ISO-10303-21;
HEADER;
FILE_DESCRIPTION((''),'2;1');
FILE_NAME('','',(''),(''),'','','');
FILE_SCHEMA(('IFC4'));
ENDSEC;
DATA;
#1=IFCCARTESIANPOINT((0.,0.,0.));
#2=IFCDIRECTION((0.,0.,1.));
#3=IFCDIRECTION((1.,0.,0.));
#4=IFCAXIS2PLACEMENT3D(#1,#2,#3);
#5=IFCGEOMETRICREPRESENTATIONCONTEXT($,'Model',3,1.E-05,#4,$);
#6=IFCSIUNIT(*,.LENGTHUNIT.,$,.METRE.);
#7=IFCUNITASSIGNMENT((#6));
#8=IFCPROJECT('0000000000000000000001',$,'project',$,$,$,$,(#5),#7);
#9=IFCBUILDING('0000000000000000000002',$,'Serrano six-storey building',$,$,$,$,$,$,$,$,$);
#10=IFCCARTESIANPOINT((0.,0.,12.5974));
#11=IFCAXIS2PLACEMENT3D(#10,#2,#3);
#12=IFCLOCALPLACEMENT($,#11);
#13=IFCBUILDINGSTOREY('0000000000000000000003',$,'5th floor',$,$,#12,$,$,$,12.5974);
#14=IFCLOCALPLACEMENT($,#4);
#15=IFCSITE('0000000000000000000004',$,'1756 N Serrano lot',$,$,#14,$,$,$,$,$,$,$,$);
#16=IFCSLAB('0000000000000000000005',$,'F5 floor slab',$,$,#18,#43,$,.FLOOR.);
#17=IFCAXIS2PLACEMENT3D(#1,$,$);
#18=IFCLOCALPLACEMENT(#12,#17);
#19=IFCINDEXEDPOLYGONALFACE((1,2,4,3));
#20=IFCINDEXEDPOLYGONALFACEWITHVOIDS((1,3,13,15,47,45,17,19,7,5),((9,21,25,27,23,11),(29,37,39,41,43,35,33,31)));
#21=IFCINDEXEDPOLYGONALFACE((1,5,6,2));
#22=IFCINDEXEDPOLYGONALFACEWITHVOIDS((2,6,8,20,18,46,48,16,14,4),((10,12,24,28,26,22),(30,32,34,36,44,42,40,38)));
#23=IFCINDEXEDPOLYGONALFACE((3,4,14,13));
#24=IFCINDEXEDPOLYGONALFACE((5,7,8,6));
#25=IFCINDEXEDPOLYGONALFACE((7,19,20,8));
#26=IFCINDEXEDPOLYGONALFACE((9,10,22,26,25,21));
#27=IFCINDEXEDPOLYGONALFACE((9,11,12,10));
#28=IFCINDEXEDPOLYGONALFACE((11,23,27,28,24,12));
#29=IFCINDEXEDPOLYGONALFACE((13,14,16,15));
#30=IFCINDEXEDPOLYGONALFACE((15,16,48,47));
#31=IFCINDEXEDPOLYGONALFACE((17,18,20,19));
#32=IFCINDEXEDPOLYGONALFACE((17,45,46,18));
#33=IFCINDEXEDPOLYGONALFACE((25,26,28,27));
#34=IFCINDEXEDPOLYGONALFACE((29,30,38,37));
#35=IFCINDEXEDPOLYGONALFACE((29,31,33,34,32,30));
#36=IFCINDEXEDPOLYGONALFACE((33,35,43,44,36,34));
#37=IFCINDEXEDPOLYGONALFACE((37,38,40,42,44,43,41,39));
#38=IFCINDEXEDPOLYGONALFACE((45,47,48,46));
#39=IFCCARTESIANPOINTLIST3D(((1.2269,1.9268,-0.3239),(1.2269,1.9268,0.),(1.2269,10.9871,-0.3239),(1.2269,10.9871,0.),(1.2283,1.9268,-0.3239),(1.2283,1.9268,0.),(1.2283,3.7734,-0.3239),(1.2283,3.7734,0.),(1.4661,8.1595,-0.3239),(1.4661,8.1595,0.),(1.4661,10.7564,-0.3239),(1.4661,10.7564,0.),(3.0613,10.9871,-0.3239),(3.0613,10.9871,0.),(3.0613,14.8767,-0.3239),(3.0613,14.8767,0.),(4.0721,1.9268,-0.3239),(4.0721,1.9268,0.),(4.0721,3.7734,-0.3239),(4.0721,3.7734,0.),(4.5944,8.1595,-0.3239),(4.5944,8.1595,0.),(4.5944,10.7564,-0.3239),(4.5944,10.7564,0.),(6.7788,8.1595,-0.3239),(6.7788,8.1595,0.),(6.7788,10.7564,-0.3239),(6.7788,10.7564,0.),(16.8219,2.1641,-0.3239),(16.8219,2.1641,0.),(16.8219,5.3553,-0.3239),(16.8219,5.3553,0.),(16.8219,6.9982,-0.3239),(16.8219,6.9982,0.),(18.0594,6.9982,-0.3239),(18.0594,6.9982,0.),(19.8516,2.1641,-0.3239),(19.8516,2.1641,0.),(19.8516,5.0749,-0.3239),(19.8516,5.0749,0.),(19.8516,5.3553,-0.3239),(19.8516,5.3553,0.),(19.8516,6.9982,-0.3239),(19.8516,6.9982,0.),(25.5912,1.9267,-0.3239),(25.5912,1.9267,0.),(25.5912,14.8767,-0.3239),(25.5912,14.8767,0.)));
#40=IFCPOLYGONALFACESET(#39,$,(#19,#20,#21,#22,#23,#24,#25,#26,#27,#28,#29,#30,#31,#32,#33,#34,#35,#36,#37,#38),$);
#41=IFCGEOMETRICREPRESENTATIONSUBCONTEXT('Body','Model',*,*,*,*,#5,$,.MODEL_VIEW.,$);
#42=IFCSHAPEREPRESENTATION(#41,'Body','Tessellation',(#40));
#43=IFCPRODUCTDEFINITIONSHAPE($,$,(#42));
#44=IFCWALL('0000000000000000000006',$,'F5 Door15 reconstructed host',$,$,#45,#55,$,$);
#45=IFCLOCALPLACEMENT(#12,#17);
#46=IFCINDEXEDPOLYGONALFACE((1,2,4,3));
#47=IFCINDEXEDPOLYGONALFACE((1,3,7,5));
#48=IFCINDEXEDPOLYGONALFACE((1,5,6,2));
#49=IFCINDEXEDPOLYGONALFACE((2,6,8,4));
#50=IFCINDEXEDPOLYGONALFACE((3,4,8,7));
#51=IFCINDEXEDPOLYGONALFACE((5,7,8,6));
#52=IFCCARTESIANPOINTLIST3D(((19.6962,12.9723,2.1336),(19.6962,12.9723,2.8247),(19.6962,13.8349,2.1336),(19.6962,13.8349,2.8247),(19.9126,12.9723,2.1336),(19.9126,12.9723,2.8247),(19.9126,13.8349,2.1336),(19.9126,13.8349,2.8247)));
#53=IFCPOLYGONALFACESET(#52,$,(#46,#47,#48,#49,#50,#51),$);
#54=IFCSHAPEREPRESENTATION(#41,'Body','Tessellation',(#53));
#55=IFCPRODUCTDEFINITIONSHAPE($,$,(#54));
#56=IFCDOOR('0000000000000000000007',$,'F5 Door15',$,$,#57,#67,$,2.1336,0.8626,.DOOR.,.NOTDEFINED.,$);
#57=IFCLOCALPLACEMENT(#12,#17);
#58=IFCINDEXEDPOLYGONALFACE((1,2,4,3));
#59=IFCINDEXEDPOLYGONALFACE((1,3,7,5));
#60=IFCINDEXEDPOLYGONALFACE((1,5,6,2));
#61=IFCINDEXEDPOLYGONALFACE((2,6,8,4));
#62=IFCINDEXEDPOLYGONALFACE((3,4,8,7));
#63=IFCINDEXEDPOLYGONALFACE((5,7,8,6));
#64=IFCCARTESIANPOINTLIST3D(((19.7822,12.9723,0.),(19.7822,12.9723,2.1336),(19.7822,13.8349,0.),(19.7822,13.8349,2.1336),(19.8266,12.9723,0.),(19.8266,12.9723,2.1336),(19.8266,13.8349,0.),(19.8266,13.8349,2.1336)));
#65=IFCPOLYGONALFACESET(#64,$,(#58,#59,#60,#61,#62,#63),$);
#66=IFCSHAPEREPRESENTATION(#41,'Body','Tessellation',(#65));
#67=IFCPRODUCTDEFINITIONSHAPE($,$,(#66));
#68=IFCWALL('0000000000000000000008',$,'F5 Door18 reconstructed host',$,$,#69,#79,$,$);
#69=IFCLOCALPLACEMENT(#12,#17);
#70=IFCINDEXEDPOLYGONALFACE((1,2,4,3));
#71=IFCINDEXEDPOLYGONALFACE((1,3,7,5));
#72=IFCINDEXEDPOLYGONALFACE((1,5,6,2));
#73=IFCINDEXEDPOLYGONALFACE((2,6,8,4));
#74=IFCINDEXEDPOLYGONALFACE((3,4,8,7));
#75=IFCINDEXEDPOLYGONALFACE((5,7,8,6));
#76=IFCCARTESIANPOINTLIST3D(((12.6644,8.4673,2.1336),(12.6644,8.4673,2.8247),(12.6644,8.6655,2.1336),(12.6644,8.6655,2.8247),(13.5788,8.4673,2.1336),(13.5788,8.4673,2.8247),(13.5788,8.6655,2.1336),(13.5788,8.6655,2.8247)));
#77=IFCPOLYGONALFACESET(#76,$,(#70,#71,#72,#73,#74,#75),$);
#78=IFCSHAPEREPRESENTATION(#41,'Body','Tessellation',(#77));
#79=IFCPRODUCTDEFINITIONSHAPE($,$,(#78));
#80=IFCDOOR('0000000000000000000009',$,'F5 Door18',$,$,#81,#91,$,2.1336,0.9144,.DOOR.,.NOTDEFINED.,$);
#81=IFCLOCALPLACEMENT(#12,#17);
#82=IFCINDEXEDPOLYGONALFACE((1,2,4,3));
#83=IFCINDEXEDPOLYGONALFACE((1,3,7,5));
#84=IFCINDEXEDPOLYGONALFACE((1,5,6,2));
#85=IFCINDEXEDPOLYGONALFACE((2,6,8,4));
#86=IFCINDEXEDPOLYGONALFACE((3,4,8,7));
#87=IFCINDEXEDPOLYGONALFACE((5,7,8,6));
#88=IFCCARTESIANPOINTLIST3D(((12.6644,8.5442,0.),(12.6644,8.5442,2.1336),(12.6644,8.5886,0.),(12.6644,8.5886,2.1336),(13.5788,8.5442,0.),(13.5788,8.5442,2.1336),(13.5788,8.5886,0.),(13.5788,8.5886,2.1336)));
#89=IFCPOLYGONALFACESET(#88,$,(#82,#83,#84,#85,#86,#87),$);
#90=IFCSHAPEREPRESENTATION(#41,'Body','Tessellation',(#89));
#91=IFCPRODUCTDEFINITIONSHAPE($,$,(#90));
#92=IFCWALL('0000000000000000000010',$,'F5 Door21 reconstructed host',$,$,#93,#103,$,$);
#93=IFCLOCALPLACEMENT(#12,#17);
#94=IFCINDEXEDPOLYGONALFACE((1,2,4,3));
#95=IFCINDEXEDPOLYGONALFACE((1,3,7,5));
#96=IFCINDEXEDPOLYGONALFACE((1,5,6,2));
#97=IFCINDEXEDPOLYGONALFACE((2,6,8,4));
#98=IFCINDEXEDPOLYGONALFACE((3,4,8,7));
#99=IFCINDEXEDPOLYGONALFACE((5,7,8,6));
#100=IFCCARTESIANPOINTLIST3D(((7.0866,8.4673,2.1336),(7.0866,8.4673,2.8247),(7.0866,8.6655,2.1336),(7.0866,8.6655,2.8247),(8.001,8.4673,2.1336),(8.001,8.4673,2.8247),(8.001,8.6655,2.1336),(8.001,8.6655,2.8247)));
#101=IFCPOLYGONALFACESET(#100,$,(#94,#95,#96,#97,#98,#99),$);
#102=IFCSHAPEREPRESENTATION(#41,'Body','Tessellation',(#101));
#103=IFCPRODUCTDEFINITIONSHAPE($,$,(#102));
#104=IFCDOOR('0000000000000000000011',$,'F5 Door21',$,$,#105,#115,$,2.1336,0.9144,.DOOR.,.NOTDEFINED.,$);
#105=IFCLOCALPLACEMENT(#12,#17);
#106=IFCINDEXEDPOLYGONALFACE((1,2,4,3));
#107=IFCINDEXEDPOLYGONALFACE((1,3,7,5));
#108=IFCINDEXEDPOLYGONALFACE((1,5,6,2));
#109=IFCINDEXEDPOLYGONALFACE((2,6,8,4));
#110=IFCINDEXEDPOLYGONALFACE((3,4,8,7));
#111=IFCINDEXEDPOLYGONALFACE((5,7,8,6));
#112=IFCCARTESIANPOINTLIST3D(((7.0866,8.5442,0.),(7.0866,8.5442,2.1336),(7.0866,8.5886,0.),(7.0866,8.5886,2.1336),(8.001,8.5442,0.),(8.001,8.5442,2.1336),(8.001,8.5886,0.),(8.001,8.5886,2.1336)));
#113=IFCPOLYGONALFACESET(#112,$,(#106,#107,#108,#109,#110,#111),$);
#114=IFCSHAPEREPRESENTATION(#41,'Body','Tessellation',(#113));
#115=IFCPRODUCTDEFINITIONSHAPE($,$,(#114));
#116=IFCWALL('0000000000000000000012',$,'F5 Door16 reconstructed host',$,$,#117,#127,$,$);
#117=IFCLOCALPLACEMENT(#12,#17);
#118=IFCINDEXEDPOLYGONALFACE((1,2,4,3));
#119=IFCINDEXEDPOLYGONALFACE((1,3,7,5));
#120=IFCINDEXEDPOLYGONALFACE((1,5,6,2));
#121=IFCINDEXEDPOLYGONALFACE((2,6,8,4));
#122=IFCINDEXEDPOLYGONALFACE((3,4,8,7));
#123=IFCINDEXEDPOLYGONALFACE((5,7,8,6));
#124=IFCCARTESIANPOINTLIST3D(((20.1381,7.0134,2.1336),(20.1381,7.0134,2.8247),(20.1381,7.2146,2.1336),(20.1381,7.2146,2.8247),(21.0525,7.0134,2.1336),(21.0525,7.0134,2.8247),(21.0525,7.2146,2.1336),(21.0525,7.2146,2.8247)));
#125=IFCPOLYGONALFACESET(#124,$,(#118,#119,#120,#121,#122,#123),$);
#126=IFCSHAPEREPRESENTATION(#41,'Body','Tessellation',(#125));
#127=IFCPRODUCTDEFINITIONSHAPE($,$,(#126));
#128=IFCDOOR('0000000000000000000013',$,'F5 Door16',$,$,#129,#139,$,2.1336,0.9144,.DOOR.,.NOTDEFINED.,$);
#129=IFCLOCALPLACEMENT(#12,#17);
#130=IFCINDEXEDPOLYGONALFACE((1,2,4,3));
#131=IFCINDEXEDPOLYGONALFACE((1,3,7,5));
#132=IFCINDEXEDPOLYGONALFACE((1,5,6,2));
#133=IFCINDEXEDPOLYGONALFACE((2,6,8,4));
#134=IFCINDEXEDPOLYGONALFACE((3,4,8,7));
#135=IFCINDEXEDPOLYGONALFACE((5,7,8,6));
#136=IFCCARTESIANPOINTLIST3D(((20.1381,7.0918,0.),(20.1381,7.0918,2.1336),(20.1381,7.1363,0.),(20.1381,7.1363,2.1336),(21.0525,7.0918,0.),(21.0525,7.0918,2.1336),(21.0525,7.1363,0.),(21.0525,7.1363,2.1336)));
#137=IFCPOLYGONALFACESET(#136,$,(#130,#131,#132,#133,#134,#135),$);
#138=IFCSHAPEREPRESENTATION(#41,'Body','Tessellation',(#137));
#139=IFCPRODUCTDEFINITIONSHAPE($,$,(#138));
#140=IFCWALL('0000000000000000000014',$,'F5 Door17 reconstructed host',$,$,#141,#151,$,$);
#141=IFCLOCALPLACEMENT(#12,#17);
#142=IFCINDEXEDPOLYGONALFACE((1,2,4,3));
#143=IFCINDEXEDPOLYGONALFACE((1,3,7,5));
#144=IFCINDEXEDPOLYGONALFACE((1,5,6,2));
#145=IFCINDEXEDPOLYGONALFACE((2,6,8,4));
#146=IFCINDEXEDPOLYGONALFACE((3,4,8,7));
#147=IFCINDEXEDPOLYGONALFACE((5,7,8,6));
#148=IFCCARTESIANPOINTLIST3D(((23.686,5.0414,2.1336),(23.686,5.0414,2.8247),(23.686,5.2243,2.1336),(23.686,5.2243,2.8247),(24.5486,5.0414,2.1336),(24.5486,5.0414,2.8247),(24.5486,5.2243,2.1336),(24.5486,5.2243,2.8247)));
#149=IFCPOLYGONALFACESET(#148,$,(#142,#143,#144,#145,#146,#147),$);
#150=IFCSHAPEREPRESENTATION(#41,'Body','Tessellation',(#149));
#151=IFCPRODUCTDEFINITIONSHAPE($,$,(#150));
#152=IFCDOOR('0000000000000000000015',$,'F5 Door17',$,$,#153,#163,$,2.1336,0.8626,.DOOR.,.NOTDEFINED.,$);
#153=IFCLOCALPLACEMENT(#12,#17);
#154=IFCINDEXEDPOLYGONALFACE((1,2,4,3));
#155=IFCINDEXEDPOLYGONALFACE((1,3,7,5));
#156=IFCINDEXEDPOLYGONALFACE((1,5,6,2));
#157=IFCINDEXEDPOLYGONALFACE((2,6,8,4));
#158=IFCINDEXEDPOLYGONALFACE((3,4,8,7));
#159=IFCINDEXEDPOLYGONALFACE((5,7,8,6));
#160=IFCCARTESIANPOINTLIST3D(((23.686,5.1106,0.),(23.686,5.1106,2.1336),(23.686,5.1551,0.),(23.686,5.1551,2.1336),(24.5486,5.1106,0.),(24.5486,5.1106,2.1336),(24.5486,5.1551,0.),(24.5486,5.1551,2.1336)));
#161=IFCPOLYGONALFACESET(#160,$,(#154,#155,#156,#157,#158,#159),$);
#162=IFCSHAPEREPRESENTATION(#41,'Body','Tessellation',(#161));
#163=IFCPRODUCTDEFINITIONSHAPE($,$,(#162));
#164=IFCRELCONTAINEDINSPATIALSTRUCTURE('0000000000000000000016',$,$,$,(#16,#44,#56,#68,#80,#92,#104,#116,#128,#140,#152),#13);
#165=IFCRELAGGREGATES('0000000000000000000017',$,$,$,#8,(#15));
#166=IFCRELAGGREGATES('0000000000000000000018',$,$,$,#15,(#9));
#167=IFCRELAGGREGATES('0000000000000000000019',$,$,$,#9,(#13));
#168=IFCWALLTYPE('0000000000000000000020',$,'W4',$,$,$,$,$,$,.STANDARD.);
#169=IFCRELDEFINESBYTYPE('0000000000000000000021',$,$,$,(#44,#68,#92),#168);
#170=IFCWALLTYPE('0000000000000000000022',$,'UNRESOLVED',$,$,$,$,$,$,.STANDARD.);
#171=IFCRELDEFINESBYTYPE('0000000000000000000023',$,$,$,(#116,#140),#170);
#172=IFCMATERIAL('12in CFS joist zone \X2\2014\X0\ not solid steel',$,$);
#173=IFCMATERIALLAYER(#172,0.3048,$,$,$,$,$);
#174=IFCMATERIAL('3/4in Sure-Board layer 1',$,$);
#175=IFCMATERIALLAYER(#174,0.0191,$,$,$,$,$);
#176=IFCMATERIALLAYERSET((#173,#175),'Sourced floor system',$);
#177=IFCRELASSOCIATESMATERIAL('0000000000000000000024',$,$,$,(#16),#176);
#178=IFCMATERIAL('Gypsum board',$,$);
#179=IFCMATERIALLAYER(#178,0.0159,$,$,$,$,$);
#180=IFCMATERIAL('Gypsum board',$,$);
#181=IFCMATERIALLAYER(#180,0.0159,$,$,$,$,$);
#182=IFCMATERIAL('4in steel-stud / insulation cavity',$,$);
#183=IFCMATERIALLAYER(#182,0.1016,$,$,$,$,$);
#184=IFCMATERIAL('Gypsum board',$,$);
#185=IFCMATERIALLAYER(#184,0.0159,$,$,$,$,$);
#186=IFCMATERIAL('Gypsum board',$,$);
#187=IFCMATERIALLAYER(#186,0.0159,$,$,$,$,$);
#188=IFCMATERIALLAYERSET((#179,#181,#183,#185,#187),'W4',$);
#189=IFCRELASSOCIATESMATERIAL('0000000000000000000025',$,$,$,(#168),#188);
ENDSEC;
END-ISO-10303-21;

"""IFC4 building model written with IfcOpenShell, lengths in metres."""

from ifc_helpers import new_model, si_unit, frame, origin_with_axes, place, context, subcontext, project, spatial, polyline, outline, extrude, material, layer, layer_set, type_object, element, fill, save


model = new_model("IFC4")

# Units and contexts
model_context = context("Model", 3, precision=1e-05, world=origin_with_axes())
body_context = subcontext(model_context, "Body", "Model", "MODEL_VIEW")
ifc_project = project(units=[si_unit("LENGTHUNIT", "METRE")], contexts=[model_context])

# Site, building, storey
site_placement = place(None, origin_with_axes())
site = spatial("IfcSite", under=ifc_project, at=site_placement, Name="1756 N Serrano lot")
building = spatial("IfcBuilding", under=site, Name="Serrano six-storey building")
storey_placement = place(None, frame((0.0, 0.0, 12.5974), z_axis=(0.0, 0.0, 1.0), x_axis=(1.0, 0.0, 0.0)))
storey = spatial("IfcBuildingStorey", under=building, at=storey_placement, Name="5th floor", Elevation=12.5974)

# Slab
ifc_material_1 = material(Name="12in CFS joist zone — not solid steel")
ifc_layer_1 = layer(ifc_material_1, 0.3048)
ifc_material_2 = material(Name="3/4in Sure-Board layer 1")
ifc_layer_2 = layer(ifc_material_2, 0.0191)
ifc_layer_set_1 = layer_set([ifc_layer_1, ifc_layer_2], Name="Sourced floor system")
slab_placement = place(storey_placement, frame((0.0, 0.0, -12.5974), z_axis=(0.0, 0.0, 1.0), x_axis=(1.0, 0.0, 0.0)))
element("IfcSlab", 1, at=slab_placement, inside=storey, material=ifc_layer_set_1, Name="F5 floor slab", PredefinedType="FLOOR", context=body_context, shape_type="SweptSolid", body=[
    extrude(outline(polyline([(3.0613, 14.8767), (25.5912, 14.8767), (25.5912, 1.9267), (4.0721, 1.9268), (4.0721, 3.7734), (1.2283, 3.7734), (1.2283, 1.9268), (1.2269, 1.9268), (1.2269, 10.9871), (3.0613, 10.9871), (3.0613, 14.8767)]), holes=[polyline([(6.7788, 10.7564), (4.5944, 10.7564), (1.4661, 10.7564), (1.4661, 8.1595), (4.5944, 8.1595), (6.7788, 8.1595), (6.7788, 10.7564)]), polyline([(16.8219, 5.3553), (16.8219, 2.1641), (19.8516, 2.1641), (19.8516, 5.0749), (19.8516, 5.3553), (19.8516, 6.9982), (18.0594, 6.9982), (16.8219, 6.9982), (16.8219, 5.3553)])]), frame((0.0, 0.0, 12.2735)), (0.0, 0.0, 1.0), 0.3239),
])

# Walls, openings, doors
ifc_material_3 = material(Name="Gypsum board")
ifc_layer_3 = layer(ifc_material_3, 0.0159)
ifc_material_4 = material(Name="Gypsum board")
ifc_layer_4 = layer(ifc_material_4, 0.0159)
ifc_material_5 = material(Name="4in steel-stud / insulation cavity")
ifc_layer_5 = layer(ifc_material_5, 0.1016)
ifc_material_6 = material(Name="Gypsum board")
ifc_layer_6 = layer(ifc_material_6, 0.0159)
ifc_material_7 = material(Name="Gypsum board")
ifc_layer_7 = layer(ifc_material_7, 0.0159)
ifc_layer_set_2 = layer_set([ifc_layer_3, ifc_layer_4, ifc_layer_5, ifc_layer_6, ifc_layer_7], Name="W4")
wall_type_1 = type_object("IfcWallType", Name="W4", PredefinedType="STANDARD", material=ifc_layer_set_2)
wall_1_placement = place(storey_placement, frame((0.0, 0.0, -12.5974), z_axis=(0.0, 0.0, 1.0), x_axis=(1.0, 0.0, 0.0)))
wall_1 = element("IfcWall", 2, at=wall_1_placement, inside=storey, type_object=wall_type_1, Name="F5 Door15 reconstructed host", context=body_context, shape_type="SweptSolid", body=[
    extrude(outline(polyline([(19.9126, 12.9723), (19.6962, 12.9723), (19.6962, 13.8349), (19.9126, 13.8349), (19.9126, 12.9723)])), frame((0.0, 0.0, 12.5974)), (0.0, 0.0, 1.0), 2.8247),
])
opening_1_placement = place(None, origin_with_axes())
opening_1 = element("IfcOpeningElement", 3, at=opening_1_placement, cuts=wall_1, PredefinedType="OPENING", context=body_context, shape_type="SweptSolid", body=[
    extrude(outline(polyline([(19.9309, 12.9723), (19.6779, 12.9723), (19.6779, 13.8349), (19.9309, 13.8349), (19.9309, 12.9723)])), frame((0.0, 0.0, 12.5974)), (0.0, 0.0, 1.0), 2.1336),
])
door_1_placement = place(storey_placement, frame((0.0, 0.0, -12.5974), z_axis=(0.0, 0.0, 1.0), x_axis=(1.0, 0.0, 0.0)))
door_1 = element("IfcDoor", 4, at=door_1_placement, inside=storey, Name="F5 Door15", OperationType="NOTDEFINED", OverallHeight=2.1336, OverallWidth=0.8626, PredefinedType="DOOR", context=body_context, shape_type="SweptSolid", body=[
    extrude(outline(polyline([(19.8266, 12.9723), (19.7822, 12.9723), (19.7822, 13.8349), (19.8266, 13.8349), (19.8266, 12.9723)])), frame((0.0, 0.0, 12.5974)), (0.0, 0.0, 1.0), 2.1336),
])
fill(opening_1, door_1)
wall_2_placement = place(storey_placement, frame((0.0, 0.0, -12.5974), z_axis=(0.0, 0.0, 1.0), x_axis=(1.0, 0.0, 0.0)))
wall_2 = element("IfcWall", 5, at=wall_2_placement, inside=storey, type_object=wall_type_1, Name="F5 Door18 reconstructed host", context=body_context, shape_type="SweptSolid", body=[
    extrude(outline(polyline([(13.5788, 8.6655), (13.5788, 8.4673), (12.6644, 8.4673), (12.6644, 8.6655), (13.5788, 8.6655)])), frame((0.0, 0.0, 12.5974)), (0.0, 0.0, 1.0), 2.8247),
])
opening_2_placement = place(None, origin_with_axes())
opening_2 = element("IfcOpeningElement", 6, at=opening_2_placement, cuts=wall_2, PredefinedType="OPENING", context=body_context, shape_type="SweptSolid", body=[
    extrude(outline(polyline([(13.5788, 8.6838), (13.5788, 8.4491), (12.6644, 8.4491), (12.6644, 8.6838), (13.5788, 8.6838)])), frame((0.0, 0.0, 12.5974)), (0.0, 0.0, 1.0), 2.1336),
])
door_2_placement = place(storey_placement, frame((0.0, 0.0, -12.5974), z_axis=(0.0, 0.0, 1.0), x_axis=(1.0, 0.0, 0.0)))
door_2 = element("IfcDoor", 7, at=door_2_placement, inside=storey, Name="F5 Door18", OperationType="NOTDEFINED", OverallHeight=2.1336, OverallWidth=0.9144, PredefinedType="DOOR", context=body_context, shape_type="SweptSolid", body=[
    extrude(outline(polyline([(13.5788, 8.5886), (13.5788, 8.5442), (12.6644, 8.5442), (12.6644, 8.5886), (13.5788, 8.5886)])), frame((0.0, 0.0, 12.5974)), (0.0, 0.0, 1.0), 2.1336),
])
fill(opening_2, door_2)
wall_3_placement = place(storey_placement, frame((0.0, 0.0, -12.5974), z_axis=(0.0, 0.0, 1.0), x_axis=(1.0, 0.0, 0.0)))
wall_3 = element("IfcWall", 8, at=wall_3_placement, inside=storey, type_object=wall_type_1, Name="F5 Door21 reconstructed host", context=body_context, shape_type="SweptSolid", body=[
    extrude(outline(polyline([(8.001, 8.6655), (8.001, 8.4673), (7.0866, 8.4673), (7.0866, 8.6655), (8.001, 8.6655)])), frame((0.0, 0.0, 12.5974)), (0.0, 0.0, 1.0), 2.8247),
])
opening_3_placement = place(None, origin_with_axes())
opening_3 = element("IfcOpeningElement", 9, at=opening_3_placement, cuts=wall_3, PredefinedType="OPENING", context=body_context, shape_type="SweptSolid", body=[
    extrude(outline(polyline([(8.001, 8.6838), (8.001, 8.4491), (7.0866, 8.4491), (7.0866, 8.6838), (8.001, 8.6838)])), frame((0.0, 0.0, 12.5974)), (0.0, 0.0, 1.0), 2.1336),
])
door_3_placement = place(storey_placement, frame((0.0, 0.0, -12.5974), z_axis=(0.0, 0.0, 1.0), x_axis=(1.0, 0.0, 0.0)))
door_3 = element("IfcDoor", 10, at=door_3_placement, inside=storey, Name="F5 Door21", OperationType="NOTDEFINED", OverallHeight=2.1336, OverallWidth=0.9144, PredefinedType="DOOR", context=body_context, shape_type="SweptSolid", body=[
    extrude(outline(polyline([(8.001, 8.5886), (8.001, 8.5442), (7.0866, 8.5442), (7.0866, 8.5886), (8.001, 8.5886)])), frame((0.0, 0.0, 12.5974)), (0.0, 0.0, 1.0), 2.1336),
])
fill(opening_3, door_3)
wall_type_2 = type_object("IfcWallType", Name="UNRESOLVED", PredefinedType="STANDARD")
wall_4_placement = place(storey_placement, frame((0.0, 0.0, -12.5974), z_axis=(0.0, 0.0, 1.0), x_axis=(1.0, 0.0, 0.0)))
wall_4 = element("IfcWall", 11, at=wall_4_placement, inside=storey, type_object=wall_type_2, Name="F5 Door16 reconstructed host", context=body_context, shape_type="SweptSolid", body=[
    extrude(outline(polyline([(21.0525, 7.2146), (21.0525, 7.0134), (20.1381, 7.0134), (20.1381, 7.2146), (21.0525, 7.2146)])), frame((0.0, 0.0, 12.5974)), (0.0, 0.0, 1.0), 2.8247),
])
opening_4_placement = place(None, origin_with_axes())
opening_4 = element("IfcOpeningElement", 12, at=opening_4_placement, cuts=wall_4, PredefinedType="OPENING", context=body_context, shape_type="SweptSolid", body=[
    extrude(outline(polyline([(21.0525, 7.2329), (21.0525, 6.9952), (20.1381, 6.9952), (20.1381, 7.2329), (21.0525, 7.2329)])), frame((0.0, 0.0, 12.5974)), (0.0, 0.0, 1.0), 2.1336),
])
door_4_placement = place(storey_placement, frame((0.0, 0.0, -12.5974), z_axis=(0.0, 0.0, 1.0), x_axis=(1.0, 0.0, 0.0)))
door_4 = element("IfcDoor", 13, at=door_4_placement, inside=storey, Name="F5 Door16", OperationType="NOTDEFINED", OverallHeight=2.1336, OverallWidth=0.9144, PredefinedType="DOOR", context=body_context, shape_type="SweptSolid", body=[
    extrude(outline(polyline([(21.0525, 7.1363), (21.0525, 7.0918), (20.1381, 7.0918), (20.1381, 7.1363), (21.0525, 7.1363)])), frame((0.0, 0.0, 12.5974)), (0.0, 0.0, 1.0), 2.1336),
])
fill(opening_4, door_4)
wall_5_placement = place(storey_placement, frame((0.0, 0.0, -12.5974), z_axis=(0.0, 0.0, 1.0), x_axis=(1.0, 0.0, 0.0)))
wall_5 = element("IfcWall", 14, at=wall_5_placement, inside=storey, type_object=wall_type_2, Name="F5 Door17 reconstructed host", context=body_context, shape_type="SweptSolid", body=[
    extrude(outline(polyline([(23.686, 5.0414), (23.686, 5.2243), (24.5486, 5.2243), (24.5486, 5.0414), (23.686, 5.0414)])), frame((0.0, 0.0, 12.5974)), (0.0, 0.0, 1.0), 2.8247),
])
opening_5_placement = place(None, origin_with_axes())
opening_5 = element("IfcOpeningElement", 15, at=opening_5_placement, cuts=wall_5, PredefinedType="OPENING", context=body_context, shape_type="SweptSolid", body=[
    extrude(outline(polyline([(23.686, 5.0231), (23.686, 5.2426), (24.5486, 5.2426), (24.5486, 5.0231), (23.686, 5.0231)])), frame((0.0, 0.0, 12.5974)), (0.0, 0.0, 1.0), 2.1336),
])
door_5_placement = place(storey_placement, frame((0.0, 0.0, -12.5974), z_axis=(0.0, 0.0, 1.0), x_axis=(1.0, 0.0, 0.0)))
door_5 = element("IfcDoor", 16, at=door_5_placement, inside=storey, Name="F5 Door17", OperationType="NOTDEFINED", OverallHeight=2.1336, OverallWidth=0.8626, PredefinedType="DOOR", context=body_context, shape_type="SweptSolid", body=[
    extrude(outline(polyline([(23.686, 5.1106), (23.686, 5.1551), (24.5486, 5.1551), (24.5486, 5.1106), (23.686, 5.1106)])), frame((0.0, 0.0, 12.5974)), (0.0, 0.0, 1.0), 2.1336),
])
fill(opening_5, door_5)

save(model, "model.ifc")
